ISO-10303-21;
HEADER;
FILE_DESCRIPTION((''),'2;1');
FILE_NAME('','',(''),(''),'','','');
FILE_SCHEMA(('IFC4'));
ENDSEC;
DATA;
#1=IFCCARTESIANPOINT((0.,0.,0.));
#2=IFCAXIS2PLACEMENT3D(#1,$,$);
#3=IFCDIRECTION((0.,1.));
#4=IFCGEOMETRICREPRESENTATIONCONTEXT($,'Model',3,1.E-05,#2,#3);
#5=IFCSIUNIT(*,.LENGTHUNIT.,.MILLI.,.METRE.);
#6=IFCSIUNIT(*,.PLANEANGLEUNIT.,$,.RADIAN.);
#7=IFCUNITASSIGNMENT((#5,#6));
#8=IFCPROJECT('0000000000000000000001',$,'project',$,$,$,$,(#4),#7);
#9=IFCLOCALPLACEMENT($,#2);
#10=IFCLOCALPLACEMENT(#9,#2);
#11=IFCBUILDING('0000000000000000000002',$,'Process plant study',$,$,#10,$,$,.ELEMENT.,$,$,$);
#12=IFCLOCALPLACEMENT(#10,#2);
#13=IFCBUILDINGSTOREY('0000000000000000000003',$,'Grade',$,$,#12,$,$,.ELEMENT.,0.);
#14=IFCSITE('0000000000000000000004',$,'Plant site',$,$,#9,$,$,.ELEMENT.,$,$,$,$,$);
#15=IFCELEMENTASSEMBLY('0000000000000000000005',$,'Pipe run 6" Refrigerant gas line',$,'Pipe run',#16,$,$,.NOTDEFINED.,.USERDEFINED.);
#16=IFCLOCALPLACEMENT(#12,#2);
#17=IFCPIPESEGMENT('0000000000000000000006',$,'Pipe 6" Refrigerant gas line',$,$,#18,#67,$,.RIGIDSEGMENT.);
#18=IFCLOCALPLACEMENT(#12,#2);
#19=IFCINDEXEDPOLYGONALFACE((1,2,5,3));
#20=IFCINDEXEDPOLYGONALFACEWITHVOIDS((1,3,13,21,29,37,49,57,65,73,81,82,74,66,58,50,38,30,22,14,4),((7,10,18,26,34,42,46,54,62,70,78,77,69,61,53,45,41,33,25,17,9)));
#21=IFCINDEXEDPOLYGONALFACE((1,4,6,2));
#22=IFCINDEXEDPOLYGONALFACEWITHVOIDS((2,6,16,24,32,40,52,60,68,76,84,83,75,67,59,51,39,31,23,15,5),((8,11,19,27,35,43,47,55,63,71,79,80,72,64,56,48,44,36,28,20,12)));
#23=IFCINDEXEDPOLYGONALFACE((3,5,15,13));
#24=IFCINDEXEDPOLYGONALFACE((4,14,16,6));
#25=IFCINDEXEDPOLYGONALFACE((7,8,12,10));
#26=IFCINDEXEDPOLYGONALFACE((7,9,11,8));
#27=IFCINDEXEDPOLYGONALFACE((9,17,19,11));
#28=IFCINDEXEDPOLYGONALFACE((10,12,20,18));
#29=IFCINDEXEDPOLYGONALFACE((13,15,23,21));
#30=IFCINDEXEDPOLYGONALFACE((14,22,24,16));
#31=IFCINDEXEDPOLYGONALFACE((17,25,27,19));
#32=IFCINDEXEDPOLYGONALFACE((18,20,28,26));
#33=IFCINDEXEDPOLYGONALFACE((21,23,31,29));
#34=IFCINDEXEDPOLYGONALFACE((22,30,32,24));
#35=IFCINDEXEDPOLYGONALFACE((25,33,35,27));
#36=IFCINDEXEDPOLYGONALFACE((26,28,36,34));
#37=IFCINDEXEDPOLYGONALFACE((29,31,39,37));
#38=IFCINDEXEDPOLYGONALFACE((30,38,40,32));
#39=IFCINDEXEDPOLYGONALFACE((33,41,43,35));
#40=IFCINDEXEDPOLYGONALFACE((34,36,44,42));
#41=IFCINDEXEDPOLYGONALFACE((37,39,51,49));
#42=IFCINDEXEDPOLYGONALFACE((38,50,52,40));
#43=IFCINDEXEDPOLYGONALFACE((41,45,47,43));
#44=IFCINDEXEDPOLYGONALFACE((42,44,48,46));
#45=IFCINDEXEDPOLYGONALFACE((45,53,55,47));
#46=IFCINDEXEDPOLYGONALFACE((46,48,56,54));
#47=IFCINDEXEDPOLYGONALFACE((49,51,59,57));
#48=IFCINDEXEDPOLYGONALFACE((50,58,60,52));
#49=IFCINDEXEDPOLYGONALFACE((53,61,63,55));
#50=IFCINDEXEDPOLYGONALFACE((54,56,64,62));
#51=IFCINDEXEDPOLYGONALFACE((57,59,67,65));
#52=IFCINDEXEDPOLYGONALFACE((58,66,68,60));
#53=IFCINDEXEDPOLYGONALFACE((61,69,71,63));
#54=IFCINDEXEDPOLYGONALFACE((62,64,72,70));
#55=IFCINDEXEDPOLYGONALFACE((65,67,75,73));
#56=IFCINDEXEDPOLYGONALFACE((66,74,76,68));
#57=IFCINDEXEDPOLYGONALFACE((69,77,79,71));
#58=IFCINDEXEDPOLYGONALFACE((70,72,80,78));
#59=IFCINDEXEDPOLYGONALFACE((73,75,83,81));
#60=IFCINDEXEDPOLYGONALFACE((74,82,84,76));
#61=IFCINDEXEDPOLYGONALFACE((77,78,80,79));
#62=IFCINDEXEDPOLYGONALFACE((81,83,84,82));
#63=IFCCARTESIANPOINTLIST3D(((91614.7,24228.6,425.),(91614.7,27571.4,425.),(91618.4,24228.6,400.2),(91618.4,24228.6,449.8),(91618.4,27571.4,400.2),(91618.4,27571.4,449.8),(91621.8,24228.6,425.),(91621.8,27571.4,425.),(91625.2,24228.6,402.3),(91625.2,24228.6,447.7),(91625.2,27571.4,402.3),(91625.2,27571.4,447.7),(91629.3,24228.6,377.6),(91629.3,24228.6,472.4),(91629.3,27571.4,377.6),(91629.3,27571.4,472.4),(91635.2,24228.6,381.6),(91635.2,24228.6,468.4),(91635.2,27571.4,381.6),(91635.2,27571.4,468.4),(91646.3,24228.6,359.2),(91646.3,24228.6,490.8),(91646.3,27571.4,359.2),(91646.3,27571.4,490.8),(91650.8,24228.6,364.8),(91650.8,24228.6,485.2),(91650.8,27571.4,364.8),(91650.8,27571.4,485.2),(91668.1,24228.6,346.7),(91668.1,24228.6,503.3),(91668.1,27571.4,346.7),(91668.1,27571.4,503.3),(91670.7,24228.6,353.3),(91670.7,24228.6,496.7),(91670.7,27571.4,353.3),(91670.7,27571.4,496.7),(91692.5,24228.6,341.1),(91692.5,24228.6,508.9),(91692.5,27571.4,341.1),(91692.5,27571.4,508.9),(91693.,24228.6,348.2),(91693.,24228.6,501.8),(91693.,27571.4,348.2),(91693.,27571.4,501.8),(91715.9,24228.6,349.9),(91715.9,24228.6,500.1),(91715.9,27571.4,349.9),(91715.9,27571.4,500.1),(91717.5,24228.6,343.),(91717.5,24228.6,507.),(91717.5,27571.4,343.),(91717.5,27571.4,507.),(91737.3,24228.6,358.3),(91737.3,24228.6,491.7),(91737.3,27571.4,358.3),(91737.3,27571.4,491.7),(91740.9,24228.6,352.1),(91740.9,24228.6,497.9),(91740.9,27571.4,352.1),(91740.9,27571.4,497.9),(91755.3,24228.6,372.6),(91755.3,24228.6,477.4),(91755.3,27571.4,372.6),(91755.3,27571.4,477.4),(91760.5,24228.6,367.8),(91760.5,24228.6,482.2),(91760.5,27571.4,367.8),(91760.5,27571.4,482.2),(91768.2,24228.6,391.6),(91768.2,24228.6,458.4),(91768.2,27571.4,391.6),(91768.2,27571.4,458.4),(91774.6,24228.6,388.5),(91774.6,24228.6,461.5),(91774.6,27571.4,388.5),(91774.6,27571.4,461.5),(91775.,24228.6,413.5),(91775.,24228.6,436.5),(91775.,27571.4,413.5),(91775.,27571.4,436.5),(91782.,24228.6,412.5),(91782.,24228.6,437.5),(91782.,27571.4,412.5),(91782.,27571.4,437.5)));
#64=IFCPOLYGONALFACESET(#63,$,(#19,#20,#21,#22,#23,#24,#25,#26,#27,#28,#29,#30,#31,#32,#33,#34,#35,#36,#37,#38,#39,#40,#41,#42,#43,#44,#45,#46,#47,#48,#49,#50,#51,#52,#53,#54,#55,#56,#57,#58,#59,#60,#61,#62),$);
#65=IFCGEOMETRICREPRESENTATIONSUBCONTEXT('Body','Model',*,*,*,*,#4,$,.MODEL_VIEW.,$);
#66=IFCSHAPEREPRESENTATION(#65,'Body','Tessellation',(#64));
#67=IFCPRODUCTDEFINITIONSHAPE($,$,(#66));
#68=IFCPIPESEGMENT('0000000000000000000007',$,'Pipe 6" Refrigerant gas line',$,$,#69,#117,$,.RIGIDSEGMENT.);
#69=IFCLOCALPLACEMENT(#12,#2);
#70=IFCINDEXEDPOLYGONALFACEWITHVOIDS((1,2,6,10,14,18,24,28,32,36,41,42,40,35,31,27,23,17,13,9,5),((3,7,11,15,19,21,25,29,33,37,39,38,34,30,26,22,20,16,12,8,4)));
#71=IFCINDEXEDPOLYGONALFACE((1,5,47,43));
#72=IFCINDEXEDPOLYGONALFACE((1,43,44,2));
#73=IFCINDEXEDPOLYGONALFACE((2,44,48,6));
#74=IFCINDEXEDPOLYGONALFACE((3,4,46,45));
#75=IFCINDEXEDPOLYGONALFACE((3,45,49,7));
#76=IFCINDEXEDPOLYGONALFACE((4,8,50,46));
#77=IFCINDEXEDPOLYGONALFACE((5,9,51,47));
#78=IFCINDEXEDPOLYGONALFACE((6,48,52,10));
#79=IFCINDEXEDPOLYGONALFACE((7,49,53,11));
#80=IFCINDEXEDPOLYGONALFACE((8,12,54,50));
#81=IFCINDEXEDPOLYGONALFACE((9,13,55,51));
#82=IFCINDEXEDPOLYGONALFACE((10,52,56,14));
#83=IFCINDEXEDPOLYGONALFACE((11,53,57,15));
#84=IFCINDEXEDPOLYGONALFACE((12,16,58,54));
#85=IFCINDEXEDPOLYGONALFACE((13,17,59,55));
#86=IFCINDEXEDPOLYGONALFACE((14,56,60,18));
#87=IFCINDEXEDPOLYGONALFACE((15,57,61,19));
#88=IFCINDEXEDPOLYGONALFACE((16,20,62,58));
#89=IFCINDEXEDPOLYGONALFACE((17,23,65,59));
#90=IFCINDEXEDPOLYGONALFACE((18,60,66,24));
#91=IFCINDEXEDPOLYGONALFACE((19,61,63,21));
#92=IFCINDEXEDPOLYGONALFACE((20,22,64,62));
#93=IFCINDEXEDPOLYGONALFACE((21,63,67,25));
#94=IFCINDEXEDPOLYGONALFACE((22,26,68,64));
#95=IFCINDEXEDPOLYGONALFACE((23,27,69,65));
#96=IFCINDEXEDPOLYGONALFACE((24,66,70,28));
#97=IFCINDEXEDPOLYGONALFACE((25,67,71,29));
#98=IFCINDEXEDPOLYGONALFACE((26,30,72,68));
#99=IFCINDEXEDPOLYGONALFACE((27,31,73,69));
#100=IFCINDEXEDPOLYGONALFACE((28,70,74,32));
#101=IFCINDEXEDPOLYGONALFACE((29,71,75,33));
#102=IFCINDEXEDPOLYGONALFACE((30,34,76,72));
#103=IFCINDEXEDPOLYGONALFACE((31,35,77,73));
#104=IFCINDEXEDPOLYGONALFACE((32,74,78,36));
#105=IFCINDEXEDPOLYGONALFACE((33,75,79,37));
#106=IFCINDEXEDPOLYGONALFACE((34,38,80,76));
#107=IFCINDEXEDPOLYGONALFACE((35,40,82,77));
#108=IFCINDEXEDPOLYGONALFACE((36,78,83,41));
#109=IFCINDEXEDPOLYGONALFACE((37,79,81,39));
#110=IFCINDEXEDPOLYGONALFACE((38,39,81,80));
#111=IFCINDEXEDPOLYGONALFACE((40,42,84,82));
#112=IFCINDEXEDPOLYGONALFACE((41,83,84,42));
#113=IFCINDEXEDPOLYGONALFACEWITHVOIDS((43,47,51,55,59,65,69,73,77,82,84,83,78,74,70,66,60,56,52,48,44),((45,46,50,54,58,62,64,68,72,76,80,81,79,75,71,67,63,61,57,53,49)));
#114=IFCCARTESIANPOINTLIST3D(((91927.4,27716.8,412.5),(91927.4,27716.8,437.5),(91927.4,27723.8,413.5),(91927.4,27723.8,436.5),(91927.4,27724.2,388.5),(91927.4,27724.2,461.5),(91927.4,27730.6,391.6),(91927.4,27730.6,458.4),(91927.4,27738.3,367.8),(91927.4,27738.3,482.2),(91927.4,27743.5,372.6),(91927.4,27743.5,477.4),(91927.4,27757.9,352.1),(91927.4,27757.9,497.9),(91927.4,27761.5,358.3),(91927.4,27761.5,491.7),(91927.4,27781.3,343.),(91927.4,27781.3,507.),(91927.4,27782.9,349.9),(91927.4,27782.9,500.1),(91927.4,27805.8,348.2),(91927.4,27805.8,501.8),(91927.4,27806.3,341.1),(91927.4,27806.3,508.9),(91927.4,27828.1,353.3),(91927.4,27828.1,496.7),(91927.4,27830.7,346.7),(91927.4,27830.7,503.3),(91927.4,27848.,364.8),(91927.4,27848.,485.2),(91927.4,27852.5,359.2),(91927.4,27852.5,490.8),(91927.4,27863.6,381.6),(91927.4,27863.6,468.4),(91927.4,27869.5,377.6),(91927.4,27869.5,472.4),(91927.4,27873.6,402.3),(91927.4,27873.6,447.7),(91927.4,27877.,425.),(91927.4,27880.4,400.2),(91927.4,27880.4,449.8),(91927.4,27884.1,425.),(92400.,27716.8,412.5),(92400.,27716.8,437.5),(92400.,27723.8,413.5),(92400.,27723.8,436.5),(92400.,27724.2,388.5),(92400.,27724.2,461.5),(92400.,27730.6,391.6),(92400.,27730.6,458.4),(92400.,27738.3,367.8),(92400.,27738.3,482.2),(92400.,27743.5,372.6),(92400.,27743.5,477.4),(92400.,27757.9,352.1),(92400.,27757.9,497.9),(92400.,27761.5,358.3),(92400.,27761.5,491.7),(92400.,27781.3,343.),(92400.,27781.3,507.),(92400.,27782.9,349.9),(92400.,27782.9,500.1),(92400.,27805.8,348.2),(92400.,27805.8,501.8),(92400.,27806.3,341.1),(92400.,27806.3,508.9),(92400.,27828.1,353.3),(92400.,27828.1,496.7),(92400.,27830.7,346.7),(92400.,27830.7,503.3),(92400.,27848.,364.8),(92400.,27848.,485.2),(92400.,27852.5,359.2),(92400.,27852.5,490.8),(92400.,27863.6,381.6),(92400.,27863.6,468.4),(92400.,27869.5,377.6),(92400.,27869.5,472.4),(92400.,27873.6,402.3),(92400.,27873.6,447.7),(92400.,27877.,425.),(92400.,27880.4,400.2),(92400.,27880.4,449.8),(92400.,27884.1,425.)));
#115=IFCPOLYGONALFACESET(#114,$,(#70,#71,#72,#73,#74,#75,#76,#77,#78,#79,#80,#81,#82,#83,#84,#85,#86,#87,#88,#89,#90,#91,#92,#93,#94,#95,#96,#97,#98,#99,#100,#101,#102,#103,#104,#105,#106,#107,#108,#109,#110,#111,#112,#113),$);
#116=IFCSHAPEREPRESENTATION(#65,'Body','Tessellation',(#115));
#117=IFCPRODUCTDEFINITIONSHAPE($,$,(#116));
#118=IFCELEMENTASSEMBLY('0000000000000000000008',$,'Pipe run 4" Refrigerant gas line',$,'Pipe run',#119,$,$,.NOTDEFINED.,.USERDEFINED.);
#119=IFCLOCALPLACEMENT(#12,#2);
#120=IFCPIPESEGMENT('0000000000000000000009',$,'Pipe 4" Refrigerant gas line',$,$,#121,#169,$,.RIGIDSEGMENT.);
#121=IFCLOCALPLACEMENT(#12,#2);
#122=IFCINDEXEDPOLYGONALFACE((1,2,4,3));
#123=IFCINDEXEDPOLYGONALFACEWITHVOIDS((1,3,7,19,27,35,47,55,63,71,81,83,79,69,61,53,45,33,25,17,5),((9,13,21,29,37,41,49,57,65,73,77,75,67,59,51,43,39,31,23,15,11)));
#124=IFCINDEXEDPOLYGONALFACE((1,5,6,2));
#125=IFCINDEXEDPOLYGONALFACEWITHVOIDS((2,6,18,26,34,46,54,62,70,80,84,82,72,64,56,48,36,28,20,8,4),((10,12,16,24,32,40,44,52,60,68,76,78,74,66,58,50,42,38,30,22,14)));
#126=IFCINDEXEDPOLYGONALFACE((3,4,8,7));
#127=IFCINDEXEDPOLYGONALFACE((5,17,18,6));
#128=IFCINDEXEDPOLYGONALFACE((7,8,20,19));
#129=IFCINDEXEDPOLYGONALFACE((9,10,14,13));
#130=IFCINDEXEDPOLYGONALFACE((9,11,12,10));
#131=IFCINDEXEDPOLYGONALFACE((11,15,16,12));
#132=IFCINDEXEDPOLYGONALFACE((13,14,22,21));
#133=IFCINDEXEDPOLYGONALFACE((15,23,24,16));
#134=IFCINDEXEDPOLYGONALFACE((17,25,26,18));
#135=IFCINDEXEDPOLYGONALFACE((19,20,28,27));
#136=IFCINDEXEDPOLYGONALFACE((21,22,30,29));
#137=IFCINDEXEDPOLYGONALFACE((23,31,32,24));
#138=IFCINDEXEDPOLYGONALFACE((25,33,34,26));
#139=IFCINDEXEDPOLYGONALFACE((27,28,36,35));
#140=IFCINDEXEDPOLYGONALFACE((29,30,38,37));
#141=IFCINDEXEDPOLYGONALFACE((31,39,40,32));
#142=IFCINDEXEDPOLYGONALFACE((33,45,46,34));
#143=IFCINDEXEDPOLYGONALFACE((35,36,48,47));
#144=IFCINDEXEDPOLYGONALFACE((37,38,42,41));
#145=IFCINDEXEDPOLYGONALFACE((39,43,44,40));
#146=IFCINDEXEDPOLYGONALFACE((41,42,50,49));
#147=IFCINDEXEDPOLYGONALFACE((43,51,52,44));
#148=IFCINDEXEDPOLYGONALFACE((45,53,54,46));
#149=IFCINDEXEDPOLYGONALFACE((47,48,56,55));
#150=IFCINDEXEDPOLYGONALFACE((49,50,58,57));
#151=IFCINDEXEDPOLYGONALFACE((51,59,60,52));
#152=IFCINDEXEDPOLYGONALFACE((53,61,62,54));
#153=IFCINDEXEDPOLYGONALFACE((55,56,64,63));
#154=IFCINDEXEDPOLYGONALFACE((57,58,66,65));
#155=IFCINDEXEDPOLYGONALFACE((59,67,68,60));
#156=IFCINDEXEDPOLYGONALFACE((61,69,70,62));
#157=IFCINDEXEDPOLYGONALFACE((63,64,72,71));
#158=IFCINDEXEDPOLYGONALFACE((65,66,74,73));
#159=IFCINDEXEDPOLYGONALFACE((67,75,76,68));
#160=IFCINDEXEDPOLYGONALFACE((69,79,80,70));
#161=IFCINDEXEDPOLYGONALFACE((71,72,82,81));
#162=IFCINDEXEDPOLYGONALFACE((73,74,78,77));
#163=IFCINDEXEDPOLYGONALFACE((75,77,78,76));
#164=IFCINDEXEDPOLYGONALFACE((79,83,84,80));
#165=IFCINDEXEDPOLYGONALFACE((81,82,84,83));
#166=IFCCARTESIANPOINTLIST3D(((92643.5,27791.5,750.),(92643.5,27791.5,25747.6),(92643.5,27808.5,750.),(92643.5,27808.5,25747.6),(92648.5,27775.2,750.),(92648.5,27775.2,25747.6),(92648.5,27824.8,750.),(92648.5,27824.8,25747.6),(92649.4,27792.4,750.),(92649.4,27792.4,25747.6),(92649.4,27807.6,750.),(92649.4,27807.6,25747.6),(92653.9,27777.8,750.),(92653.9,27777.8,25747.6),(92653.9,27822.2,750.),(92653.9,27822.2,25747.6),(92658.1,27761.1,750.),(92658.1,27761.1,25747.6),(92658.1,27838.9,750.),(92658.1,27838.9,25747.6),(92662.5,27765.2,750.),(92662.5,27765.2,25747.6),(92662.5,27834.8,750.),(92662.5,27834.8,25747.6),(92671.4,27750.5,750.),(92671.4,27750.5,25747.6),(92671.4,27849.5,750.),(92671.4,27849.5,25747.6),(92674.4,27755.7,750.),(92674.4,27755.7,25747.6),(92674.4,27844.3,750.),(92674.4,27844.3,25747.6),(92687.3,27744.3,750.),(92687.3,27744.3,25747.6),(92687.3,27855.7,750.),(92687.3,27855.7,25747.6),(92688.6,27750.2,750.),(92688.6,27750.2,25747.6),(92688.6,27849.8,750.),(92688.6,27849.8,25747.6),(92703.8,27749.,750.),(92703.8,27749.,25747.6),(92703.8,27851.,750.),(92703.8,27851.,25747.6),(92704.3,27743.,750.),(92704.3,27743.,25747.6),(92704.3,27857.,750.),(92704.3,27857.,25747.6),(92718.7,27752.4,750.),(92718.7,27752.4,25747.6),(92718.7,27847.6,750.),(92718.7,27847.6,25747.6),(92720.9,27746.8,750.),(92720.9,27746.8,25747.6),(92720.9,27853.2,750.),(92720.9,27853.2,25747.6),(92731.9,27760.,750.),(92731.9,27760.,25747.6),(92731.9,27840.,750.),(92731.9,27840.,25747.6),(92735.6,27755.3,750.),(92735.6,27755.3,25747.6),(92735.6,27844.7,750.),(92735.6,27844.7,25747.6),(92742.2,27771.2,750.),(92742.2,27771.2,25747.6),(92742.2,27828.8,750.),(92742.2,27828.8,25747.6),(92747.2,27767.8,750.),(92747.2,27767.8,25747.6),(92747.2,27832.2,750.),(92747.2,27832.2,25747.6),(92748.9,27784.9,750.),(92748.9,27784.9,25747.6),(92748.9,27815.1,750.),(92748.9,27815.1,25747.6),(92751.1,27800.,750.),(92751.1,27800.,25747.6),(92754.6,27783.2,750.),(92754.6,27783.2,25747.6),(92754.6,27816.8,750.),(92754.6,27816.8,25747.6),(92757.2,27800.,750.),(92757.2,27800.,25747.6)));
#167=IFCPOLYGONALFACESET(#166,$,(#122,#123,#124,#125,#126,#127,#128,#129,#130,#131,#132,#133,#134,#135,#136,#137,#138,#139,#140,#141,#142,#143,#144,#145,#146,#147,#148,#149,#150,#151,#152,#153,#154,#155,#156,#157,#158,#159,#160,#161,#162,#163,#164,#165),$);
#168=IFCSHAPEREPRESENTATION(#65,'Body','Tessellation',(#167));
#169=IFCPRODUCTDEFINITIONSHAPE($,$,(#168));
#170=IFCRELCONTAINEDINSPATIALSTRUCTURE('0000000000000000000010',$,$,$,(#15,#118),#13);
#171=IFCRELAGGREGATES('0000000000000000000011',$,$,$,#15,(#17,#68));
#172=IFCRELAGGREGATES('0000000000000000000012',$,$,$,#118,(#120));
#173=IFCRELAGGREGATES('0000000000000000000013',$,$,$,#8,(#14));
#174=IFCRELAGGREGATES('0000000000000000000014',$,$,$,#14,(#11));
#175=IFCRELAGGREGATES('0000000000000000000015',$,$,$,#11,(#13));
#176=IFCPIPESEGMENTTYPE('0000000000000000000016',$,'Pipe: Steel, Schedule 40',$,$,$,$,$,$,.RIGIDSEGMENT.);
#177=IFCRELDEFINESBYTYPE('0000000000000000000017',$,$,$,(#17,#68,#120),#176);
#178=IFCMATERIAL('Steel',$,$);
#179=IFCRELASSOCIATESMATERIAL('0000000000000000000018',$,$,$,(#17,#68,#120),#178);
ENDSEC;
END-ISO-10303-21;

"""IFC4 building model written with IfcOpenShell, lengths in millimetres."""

from ifc_helpers import new_model, si_unit, direction, frame, origin, origin_with_axes, origin_2d, place, context, subcontext, project, spatial, hollow_circle, extrude, material, type_object, element, aggregate, save


model = new_model("IFC4")

# Units and contexts
model_context = context("Model", 3, precision=1e-05, world=origin(), true_north=direction((0.0, 1.0)))
body_context = subcontext(model_context, "Body", "Model", "MODEL_VIEW")
ifc_project = project(units=[si_unit("LENGTHUNIT", "METRE", prefix="MILLI"), si_unit("PLANEANGLEUNIT", "RADIAN")], contexts=[model_context])

# Site, building, storey
site_placement = place(None, origin())
site = spatial("IfcSite", under=ifc_project, at=site_placement, Name="Plant site", CompositionType="ELEMENT")
building_placement = place(site_placement, origin())
building = spatial("IfcBuilding", under=site, at=building_placement, Name="Process plant study", CompositionType="ELEMENT")
storey_placement = place(building_placement, origin())
storey = spatial("IfcBuildingStorey", under=building, at=storey_placement, Name="Grade", CompositionType="ELEMENT", Elevation=0.0)

# Element assemblies, pipe segments
assembly_1_placement = place(storey_placement, origin_with_axes())
assembly_1 = element("IfcElementAssembly", 1, at=assembly_1_placement, inside=storey, Name="Pipe run 6\" Refrigerant gas line", ObjectType="Pipe run", AssemblyPlace="NOTDEFINED", PredefinedType="USERDEFINED")
ifc_material = material(Name="Steel")
pipe_segment_type = type_object("IfcPipeSegmentType", Name="Pipe: Steel, Schedule 40", PredefinedType="RIGIDSEGMENT")
pipe_segment_1_placement = place(storey_placement, origin_with_axes())
pipe_segment_1 = element("IfcPipeSegment", 2, at=pipe_segment_1_placement, type_object=pipe_segment_type, material=ifc_material, Name="Pipe 6\" Refrigerant gas line", PredefinedType="RIGIDSEGMENT", context=body_context, shape_type="SweptSolid", body=[
    extrude(hollow_circle(Radius=84.1, WallThickness=7.1, at=origin_2d()), frame((91698.8, 24228.6, 425.0), z_axis=(0.0, 1.0, 0.0), x_axis=(-1.0, 0.0, 0.0)), (0.0, 0.0, 1.0), 3342.8),
])
pipe_segment_2_placement = place(storey_placement, origin_with_axes())
pipe_segment_2 = element("IfcPipeSegment", 3, at=pipe_segment_2_placement, type_object=pipe_segment_type, material=ifc_material, Name="Pipe 6\" Refrigerant gas line", PredefinedType="RIGIDSEGMENT", context=body_context, shape_type="SweptSolid", body=[
    extrude(hollow_circle(Radius=84.1, WallThickness=7.1, at=origin_2d()), frame((91927.4, 27800.0, 425.0), z_axis=(1.0, 0.0, 0.0), x_axis=(0.0, 1.0, 0.0)), (0.0, 0.0, 1.0), 472.6),
])
assembly_2_placement = place(storey_placement, origin_with_axes())
assembly_2 = element("IfcElementAssembly", 4, at=assembly_2_placement, inside=storey, Name="Pipe run 4\" Refrigerant gas line", ObjectType="Pipe run", AssemblyPlace="NOTDEFINED", PredefinedType="USERDEFINED")
pipe_segment_3_placement = place(storey_placement, origin_with_axes())
pipe_segment_3 = element("IfcPipeSegment", 5, at=pipe_segment_3_placement, type_object=pipe_segment_type, material=ifc_material, Name="Pipe 4\" Refrigerant gas line", PredefinedType="RIGIDSEGMENT", context=body_context, shape_type="SweptSolid", body=[
    extrude(hollow_circle(Radius=57.1, WallThickness=6.0, at=origin_2d()), frame((92700.0, 27800.0, 750.0), z_axis=(0.0, 0.0, 1.0), x_axis=(1.0, 0.0, 0.0)), (0.0, 0.0, 1.0), 24997.6),
])

aggregate(assembly_1, [pipe_segment_1, pipe_segment_2])
aggregate(assembly_2, [pipe_segment_3])

save(model, "model.ifc")
